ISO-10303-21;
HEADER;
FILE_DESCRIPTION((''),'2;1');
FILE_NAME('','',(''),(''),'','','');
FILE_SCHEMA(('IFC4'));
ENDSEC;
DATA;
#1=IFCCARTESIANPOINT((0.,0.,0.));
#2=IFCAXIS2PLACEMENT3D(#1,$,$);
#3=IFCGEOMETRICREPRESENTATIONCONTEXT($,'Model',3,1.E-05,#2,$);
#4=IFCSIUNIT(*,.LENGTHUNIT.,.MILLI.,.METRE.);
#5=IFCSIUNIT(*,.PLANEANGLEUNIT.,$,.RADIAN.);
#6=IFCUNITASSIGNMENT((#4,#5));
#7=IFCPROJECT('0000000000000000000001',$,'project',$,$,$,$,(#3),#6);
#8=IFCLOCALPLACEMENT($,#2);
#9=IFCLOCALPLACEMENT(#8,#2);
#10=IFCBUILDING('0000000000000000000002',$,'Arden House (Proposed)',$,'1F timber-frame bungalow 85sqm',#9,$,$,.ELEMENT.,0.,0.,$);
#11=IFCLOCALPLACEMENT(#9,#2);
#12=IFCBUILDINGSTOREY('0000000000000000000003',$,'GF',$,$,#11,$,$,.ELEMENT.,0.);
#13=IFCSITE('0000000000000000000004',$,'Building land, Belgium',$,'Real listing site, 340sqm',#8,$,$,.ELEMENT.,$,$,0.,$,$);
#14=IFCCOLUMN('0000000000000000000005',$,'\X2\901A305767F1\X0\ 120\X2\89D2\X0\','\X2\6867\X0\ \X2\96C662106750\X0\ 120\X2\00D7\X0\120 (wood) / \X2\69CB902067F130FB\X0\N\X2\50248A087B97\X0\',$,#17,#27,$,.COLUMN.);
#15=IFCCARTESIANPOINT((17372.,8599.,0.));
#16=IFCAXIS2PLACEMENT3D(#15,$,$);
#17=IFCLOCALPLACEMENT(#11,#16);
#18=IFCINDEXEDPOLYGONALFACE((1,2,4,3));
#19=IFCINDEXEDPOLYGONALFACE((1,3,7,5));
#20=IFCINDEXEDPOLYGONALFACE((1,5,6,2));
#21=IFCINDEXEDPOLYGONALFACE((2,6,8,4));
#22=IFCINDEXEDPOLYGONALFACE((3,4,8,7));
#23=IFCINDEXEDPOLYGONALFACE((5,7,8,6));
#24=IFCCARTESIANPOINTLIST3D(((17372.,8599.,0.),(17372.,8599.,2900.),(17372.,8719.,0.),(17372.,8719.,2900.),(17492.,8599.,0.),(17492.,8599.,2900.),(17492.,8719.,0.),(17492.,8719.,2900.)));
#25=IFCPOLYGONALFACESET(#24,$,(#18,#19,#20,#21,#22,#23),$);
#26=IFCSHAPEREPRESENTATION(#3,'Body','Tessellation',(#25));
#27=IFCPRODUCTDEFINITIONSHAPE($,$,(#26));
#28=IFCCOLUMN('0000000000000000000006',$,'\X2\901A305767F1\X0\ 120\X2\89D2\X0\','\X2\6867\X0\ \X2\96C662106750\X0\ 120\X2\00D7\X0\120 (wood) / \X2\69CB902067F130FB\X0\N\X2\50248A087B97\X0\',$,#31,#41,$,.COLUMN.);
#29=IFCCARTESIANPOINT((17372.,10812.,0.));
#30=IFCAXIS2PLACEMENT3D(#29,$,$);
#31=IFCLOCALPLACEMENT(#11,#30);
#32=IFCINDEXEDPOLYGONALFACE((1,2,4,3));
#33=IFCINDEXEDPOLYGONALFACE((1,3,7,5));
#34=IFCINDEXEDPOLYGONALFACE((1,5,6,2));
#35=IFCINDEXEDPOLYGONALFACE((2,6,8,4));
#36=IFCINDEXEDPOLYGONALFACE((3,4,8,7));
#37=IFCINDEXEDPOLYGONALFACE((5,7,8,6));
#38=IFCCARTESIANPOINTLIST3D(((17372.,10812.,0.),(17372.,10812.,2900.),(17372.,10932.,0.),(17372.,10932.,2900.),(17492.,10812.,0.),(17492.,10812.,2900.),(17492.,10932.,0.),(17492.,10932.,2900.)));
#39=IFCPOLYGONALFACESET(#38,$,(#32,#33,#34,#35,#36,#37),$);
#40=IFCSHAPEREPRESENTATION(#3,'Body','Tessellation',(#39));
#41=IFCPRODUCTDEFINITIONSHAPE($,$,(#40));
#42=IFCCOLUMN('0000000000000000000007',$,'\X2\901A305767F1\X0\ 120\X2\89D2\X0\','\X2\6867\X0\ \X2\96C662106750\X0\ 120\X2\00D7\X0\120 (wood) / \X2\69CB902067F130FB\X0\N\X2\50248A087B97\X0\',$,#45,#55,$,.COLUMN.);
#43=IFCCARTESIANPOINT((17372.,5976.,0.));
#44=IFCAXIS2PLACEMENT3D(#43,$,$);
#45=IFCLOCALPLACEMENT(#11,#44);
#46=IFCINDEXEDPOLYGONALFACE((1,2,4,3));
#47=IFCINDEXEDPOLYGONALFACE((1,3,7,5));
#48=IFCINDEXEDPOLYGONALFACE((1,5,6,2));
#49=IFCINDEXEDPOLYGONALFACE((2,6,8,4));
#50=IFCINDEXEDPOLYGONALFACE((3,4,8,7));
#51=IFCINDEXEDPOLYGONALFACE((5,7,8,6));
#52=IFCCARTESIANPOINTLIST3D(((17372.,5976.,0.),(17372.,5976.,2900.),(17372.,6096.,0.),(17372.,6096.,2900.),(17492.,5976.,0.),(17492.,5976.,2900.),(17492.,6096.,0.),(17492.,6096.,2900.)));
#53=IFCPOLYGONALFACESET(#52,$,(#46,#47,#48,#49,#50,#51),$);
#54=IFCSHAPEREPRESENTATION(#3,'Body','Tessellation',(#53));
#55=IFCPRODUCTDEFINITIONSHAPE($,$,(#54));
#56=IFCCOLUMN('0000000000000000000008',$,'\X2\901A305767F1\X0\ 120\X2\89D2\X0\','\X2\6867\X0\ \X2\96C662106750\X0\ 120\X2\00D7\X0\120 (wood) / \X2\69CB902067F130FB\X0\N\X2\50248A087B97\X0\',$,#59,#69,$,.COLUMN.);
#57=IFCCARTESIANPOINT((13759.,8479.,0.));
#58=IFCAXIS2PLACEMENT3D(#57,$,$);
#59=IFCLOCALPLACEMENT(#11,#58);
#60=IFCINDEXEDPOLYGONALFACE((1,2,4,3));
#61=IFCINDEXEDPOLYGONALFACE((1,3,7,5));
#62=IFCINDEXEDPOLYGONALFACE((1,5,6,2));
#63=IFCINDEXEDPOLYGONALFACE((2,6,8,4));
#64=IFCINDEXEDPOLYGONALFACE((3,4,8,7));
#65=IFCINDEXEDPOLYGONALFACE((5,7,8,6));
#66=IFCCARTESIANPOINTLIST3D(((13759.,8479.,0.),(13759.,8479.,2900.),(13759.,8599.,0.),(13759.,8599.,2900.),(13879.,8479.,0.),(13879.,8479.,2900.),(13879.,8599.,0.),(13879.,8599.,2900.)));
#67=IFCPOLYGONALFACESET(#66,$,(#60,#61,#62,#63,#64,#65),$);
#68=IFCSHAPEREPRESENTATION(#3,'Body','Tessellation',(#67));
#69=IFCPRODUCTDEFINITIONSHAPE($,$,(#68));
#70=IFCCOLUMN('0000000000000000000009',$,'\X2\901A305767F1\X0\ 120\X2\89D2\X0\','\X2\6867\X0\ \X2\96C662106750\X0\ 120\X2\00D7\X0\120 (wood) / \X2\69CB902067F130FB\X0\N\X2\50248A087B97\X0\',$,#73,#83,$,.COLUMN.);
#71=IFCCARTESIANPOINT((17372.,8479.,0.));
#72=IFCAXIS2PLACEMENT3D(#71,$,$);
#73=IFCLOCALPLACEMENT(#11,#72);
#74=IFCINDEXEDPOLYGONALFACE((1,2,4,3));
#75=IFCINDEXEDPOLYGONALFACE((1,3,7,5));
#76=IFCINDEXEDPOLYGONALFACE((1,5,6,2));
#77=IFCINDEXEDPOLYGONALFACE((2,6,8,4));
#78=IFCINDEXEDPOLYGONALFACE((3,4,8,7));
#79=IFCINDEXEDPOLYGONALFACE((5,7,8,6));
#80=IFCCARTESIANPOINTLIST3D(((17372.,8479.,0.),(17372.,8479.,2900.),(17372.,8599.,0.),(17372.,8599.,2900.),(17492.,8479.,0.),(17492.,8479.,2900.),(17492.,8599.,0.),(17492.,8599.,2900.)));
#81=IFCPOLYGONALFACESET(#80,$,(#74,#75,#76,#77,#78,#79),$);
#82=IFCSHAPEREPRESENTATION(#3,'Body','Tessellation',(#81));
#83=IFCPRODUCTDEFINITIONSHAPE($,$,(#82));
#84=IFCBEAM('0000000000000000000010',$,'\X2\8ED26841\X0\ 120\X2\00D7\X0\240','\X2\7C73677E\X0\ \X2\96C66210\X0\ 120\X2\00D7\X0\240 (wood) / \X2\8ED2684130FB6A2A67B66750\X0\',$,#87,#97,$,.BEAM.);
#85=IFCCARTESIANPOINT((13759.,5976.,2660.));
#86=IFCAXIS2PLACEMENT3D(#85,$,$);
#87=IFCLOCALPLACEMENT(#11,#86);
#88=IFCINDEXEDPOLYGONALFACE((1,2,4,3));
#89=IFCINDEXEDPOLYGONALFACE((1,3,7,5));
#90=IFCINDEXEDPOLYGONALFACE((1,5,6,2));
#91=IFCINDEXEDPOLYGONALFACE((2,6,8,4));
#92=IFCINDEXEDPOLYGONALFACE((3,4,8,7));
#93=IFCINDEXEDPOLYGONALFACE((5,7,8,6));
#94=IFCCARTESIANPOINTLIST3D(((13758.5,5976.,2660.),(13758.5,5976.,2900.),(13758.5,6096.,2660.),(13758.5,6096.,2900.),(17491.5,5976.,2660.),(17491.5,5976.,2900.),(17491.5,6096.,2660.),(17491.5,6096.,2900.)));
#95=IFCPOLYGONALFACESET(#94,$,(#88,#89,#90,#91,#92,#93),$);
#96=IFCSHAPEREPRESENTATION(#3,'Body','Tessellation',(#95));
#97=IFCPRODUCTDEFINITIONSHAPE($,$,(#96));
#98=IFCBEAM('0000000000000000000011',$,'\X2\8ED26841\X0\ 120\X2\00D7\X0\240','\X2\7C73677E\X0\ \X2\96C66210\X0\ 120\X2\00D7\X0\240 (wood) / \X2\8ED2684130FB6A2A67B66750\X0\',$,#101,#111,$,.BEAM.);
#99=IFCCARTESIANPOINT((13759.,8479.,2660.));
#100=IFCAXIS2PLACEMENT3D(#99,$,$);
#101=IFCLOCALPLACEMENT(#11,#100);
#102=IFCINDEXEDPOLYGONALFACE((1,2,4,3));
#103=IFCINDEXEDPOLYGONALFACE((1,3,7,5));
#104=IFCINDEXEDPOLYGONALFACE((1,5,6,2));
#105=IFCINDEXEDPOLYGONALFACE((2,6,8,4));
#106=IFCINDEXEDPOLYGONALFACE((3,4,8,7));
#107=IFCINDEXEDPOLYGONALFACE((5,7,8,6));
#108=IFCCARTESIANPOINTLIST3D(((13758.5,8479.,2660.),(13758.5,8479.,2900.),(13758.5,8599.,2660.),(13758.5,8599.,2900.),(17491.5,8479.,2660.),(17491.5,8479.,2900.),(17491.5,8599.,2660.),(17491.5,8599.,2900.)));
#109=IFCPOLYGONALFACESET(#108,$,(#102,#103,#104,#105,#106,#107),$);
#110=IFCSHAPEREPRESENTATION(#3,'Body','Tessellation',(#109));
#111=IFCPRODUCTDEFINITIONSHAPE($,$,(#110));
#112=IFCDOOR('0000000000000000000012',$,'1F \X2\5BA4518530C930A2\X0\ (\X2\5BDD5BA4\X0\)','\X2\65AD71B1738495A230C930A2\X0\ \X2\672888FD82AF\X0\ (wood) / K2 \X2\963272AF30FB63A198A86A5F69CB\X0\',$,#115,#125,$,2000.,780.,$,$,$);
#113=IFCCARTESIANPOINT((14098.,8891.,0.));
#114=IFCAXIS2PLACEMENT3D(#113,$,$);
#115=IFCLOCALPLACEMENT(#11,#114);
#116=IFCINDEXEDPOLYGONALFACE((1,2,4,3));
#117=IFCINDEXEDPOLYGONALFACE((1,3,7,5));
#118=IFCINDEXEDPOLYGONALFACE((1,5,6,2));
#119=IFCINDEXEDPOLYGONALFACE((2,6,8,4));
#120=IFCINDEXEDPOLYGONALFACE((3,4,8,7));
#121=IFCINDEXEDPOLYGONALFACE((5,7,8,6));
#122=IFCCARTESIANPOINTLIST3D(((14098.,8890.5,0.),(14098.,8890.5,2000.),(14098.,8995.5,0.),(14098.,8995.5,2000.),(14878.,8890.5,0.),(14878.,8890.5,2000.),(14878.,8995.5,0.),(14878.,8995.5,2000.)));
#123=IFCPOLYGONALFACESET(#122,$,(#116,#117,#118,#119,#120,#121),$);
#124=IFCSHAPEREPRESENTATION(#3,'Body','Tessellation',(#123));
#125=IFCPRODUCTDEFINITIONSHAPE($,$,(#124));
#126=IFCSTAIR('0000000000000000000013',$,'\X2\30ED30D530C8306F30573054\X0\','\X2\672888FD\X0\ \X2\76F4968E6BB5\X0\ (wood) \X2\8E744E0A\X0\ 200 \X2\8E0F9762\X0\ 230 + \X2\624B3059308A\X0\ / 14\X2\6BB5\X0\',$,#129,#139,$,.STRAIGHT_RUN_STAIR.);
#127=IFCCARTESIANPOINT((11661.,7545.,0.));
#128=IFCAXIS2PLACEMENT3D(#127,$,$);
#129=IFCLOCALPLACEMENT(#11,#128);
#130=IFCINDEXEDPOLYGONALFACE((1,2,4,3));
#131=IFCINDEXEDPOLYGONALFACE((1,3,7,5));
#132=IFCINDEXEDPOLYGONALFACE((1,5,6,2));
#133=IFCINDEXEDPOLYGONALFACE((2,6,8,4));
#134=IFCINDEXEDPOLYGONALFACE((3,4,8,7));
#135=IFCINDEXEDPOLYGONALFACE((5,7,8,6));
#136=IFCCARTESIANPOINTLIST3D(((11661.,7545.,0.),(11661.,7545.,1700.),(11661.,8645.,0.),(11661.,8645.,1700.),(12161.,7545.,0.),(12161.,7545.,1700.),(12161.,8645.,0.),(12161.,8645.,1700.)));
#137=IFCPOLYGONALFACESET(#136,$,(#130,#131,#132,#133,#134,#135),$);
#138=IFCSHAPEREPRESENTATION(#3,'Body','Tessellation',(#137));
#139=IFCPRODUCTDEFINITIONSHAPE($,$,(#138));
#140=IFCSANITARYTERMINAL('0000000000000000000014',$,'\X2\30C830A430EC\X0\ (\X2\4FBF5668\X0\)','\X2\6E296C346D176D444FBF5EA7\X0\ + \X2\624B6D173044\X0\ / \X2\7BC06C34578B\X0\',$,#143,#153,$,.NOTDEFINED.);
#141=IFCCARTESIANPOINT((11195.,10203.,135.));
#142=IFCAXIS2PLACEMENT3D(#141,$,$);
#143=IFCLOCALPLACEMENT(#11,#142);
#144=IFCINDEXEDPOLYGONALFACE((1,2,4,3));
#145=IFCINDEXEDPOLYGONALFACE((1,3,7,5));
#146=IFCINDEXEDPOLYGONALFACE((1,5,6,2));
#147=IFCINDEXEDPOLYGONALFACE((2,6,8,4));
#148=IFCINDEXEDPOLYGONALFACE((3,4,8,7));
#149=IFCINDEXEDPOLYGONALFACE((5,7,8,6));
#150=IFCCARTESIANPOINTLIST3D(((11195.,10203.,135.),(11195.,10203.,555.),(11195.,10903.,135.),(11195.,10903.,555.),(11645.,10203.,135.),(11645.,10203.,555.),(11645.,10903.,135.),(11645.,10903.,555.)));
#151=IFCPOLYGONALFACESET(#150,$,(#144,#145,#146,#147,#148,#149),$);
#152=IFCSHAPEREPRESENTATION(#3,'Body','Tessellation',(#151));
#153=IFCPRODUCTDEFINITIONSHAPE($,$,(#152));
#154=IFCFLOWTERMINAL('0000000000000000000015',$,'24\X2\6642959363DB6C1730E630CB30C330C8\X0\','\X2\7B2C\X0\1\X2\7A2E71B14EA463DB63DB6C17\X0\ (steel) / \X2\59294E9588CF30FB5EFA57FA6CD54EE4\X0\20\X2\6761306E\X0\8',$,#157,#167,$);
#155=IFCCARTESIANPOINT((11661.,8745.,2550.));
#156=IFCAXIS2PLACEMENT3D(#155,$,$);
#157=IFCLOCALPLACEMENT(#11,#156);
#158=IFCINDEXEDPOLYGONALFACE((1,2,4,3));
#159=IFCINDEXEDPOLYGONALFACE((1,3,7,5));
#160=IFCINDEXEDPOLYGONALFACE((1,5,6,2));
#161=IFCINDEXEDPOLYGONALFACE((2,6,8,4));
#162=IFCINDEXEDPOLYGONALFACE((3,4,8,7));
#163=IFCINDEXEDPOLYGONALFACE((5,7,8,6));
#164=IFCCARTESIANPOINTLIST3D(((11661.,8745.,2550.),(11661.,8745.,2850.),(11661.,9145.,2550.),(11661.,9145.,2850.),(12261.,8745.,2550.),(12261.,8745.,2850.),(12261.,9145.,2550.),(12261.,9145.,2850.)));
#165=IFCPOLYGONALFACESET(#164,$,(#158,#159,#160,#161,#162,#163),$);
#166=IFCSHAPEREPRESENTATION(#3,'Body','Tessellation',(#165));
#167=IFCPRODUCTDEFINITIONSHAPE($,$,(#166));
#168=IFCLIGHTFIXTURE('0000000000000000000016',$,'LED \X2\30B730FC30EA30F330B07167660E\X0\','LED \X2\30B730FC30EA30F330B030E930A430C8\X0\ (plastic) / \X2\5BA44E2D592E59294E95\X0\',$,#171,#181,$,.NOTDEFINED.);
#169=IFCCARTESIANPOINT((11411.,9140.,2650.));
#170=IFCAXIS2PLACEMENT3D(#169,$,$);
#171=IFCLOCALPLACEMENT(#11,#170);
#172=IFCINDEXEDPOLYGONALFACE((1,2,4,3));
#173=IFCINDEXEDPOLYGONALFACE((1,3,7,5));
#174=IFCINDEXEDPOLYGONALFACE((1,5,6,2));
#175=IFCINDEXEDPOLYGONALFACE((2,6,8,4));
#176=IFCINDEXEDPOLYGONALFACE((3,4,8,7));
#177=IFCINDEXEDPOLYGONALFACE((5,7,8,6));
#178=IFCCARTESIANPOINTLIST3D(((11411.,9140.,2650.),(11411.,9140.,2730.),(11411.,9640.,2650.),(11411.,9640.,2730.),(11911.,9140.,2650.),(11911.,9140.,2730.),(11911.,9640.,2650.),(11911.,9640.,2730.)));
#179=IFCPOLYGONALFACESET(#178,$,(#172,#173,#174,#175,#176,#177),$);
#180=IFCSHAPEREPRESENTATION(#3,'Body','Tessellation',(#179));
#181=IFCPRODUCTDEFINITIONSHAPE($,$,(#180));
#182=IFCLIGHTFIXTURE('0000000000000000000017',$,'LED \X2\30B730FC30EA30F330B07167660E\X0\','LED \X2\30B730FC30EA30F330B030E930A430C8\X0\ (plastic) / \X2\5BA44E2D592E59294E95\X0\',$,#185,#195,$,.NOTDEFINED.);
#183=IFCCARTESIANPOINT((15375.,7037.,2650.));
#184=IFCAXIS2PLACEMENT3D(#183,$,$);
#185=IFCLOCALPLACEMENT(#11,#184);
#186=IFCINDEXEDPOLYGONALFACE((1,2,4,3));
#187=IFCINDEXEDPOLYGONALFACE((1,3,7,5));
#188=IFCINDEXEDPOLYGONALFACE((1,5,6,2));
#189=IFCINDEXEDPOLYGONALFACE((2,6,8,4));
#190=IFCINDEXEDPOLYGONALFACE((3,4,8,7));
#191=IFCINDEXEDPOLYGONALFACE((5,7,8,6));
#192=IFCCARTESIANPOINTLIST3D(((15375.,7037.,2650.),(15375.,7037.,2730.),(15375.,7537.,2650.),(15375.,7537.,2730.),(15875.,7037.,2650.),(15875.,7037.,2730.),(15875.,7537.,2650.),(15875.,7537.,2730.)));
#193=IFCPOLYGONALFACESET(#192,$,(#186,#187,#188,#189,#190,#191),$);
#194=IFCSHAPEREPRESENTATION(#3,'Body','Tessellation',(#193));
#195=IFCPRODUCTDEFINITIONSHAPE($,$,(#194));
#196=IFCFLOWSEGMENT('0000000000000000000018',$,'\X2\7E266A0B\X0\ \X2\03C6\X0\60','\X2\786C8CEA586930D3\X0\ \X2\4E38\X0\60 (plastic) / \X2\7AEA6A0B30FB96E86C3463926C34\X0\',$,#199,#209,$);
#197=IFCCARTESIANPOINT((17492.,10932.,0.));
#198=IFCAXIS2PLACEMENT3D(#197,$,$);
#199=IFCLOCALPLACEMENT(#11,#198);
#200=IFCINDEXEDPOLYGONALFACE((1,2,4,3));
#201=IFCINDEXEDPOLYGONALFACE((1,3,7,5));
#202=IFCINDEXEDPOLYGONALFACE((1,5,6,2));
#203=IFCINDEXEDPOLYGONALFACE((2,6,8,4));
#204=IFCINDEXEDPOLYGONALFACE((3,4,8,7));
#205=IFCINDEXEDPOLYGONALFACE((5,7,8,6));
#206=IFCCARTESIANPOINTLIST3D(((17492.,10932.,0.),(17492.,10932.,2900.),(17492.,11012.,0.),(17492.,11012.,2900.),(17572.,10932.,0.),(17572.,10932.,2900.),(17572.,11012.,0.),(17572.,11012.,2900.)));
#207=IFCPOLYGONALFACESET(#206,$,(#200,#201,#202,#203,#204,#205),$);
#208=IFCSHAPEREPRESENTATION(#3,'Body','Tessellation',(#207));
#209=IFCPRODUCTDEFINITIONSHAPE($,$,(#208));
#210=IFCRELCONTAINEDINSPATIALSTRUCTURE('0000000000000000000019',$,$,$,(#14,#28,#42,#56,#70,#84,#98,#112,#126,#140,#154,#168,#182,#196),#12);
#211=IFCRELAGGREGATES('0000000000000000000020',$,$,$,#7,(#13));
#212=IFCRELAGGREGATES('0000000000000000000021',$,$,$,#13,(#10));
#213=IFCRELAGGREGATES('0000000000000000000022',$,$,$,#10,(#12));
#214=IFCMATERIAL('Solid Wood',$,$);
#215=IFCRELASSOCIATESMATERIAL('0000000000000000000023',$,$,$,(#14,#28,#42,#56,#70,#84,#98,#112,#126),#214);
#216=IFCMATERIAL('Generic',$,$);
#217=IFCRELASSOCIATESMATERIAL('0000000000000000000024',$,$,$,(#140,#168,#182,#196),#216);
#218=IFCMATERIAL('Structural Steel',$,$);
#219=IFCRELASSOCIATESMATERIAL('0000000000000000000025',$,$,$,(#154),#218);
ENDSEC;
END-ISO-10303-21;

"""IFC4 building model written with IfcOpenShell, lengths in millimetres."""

from ifc_helpers import new_model, si_unit, frame, frame_2d, origin, place, context, project, spatial, rectangle, extrude, material, element, save


model = new_model("IFC4")

# Units and contexts
model_context = context("Model", 3, precision=1e-05, world=origin())
ifc_project = project(units=[si_unit("LENGTHUNIT", "METRE", prefix="MILLI"), si_unit("PLANEANGLEUNIT", "RADIAN")], contexts=[model_context])

# Site, building, storey
site_placement = place(None, origin())
site = spatial("IfcSite", under=ifc_project, at=site_placement, Name="Building land, Belgium", ObjectType="Real listing site, 340sqm", CompositionType="ELEMENT", RefElevation=0.0)
building_placement = place(site_placement, origin())
building = spatial("IfcBuilding", under=site, at=building_placement, Name="Arden House (Proposed)", ObjectType="1F timber-frame bungalow 85sqm", CompositionType="ELEMENT", ElevationOfRefHeight=0.0, ElevationOfTerrain=0.0)
storey_placement = place(building_placement, origin())
storey = spatial("IfcBuildingStorey", under=building, at=storey_placement, Name="GF", CompositionType="ELEMENT", Elevation=0.0)

# Columns
ifc_material_1 = material(Name="Solid Wood")
column_1_placement = place(storey_placement, frame((17372.0, 8599.0, 0.0)))
element("IfcColumn", 1, at=column_1_placement, inside=storey, material=ifc_material_1, Name="通し柱 120角", Description="桧 集成材 120×120 (wood) / 構造柱・N値計算", PredefinedType="COLUMN", context=model_context, shape_type="SweptSolid", body=[
    extrude(rectangle(XDim=120.0, YDim=120.0, at=frame_2d((60.0, 60.0))), frame((17372.0, 8599.0, 0.0)), (0.0, 0.0, 1.0), 2900.0),
])
column_2_placement = place(storey_placement, frame((17372.0, 10812.0, 0.0)))
element("IfcColumn", 2, at=column_2_placement, inside=storey, material=ifc_material_1, Name="通し柱 120角", Description="桧 集成材 120×120 (wood) / 構造柱・N値計算", PredefinedType="COLUMN", context=model_context, shape_type="SweptSolid", body=[
    extrude(rectangle(XDim=120.0, YDim=120.0, at=frame_2d((60.0, 60.0))), frame((17372.0, 10812.0, 0.0)), (0.0, 0.0, 1.0), 2900.0),
])
column_3_placement = place(storey_placement, frame((17372.0, 5976.0, 0.0)))
element("IfcColumn", 3, at=column_3_placement, inside=storey, material=ifc_material_1, Name="通し柱 120角", Description="桧 集成材 120×120 (wood) / 構造柱・N値計算", PredefinedType="COLUMN", context=model_context, shape_type="SweptSolid", body=[
    extrude(rectangle(XDim=120.0, YDim=120.0, at=frame_2d((60.0, 60.0))), frame((17372.0, 5976.0, 0.0)), (0.0, 0.0, 1.0), 2900.0),
])
column_4_placement = place(storey_placement, frame((13759.0, 8479.0, 0.0)))
element("IfcColumn", 4, at=column_4_placement, inside=storey, material=ifc_material_1, Name="通し柱 120角", Description="桧 集成材 120×120 (wood) / 構造柱・N値計算", PredefinedType="COLUMN", context=model_context, shape_type="SweptSolid", body=[
    extrude(rectangle(XDim=120.0, YDim=120.0, at=frame_2d((60.0, 60.0))), frame((13759.0, 8479.0, 0.0)), (0.0, 0.0, 1.0), 2900.0),
])
column_5_placement = place(storey_placement, frame((17372.0, 8479.0, 0.0)))
element("IfcColumn", 5, at=column_5_placement, inside=storey, material=ifc_material_1, Name="通し柱 120角", Description="桧 集成材 120×120 (wood) / 構造柱・N値計算", PredefinedType="COLUMN", context=model_context, shape_type="SweptSolid", body=[
    extrude(rectangle(XDim=120.0, YDim=120.0, at=frame_2d((60.0, 60.0))), frame((17372.0, 8479.0, 0.0)), (0.0, 0.0, 1.0), 2900.0),
])

# Beams
beam_1_placement = place(storey_placement, frame((13759.0, 5976.0, 2660.0)))
element("IfcBeam", 6, at=beam_1_placement, inside=storey, material=ifc_material_1, Name="軒桁 120×240", Description="米松 集成 120×240 (wood) / 軒桁・横架材", PredefinedType="BEAM", context=model_context, shape_type="SweptSolid", body=[
    extrude(rectangle(XDim=3733.0, YDim=120.0, at=frame_2d((1866.0, 60.0))), frame((13759.0, 5976.0, 2660.0)), (0.0, 0.0, 1.0), 240.0),
])
beam_2_placement = place(storey_placement, frame((13759.0, 8479.0, 2660.0)))
element("IfcBeam", 7, at=beam_2_placement, inside=storey, material=ifc_material_1, Name="軒桁 120×240", Description="米松 集成 120×240 (wood) / 軒桁・横架材", PredefinedType="BEAM", context=model_context, shape_type="SweptSolid", body=[
    extrude(rectangle(XDim=3733.0, YDim=120.0, at=frame_2d((1866.0, 60.0))), frame((13759.0, 8479.0, 2660.0)), (0.0, 0.0, 1.0), 240.0),
])

# Door
door_placement = place(storey_placement, frame((14098.0, 8891.0, 0.0)))
element("IfcDoor", 8, at=door_placement, inside=storey, material=ifc_material_1, Name="1F 室内ドア (寝室)", Description="断熱玄関ドア 木製芯 (wood) / K2 防犯・採風機構", OverallHeight=2000.0, OverallWidth=780.0, context=model_context, shape_type="SweptSolid", body=[
    extrude(rectangle(XDim=780.0, YDim=105.0, at=frame_2d((390.0, 52.0))), frame((14098.0, 8891.0, 0.0)), (0.0, 0.0, 1.0), 2000.0),
])

# Stair
stair_placement = place(storey_placement, frame((11661.0, 7545.0, 0.0)))
element("IfcStair", 9, at=stair_placement, inside=storey, material=ifc_material_1, Name="ロフトはしご", Description="木製 直階段 (wood) 蹴上 200 踏面 230 + 手すり / 14段", PredefinedType="STRAIGHT_RUN_STAIR", context=model_context, shape_type="SweptSolid", body=[
    extrude(rectangle(XDim=500.0, YDim=1100.0, at=frame_2d((250.0, 550.0))), frame((11661.0, 7545.0, 0.0)), (0.0, 0.0, 1.0), 1700.0),
])

# Shared definitions
ifc_material_2 = material(Name="Generic")

# Sanitary terminal
sanitary_terminal_placement = place(storey_placement, frame((11195.0, 10203.0, 135.0)))
element("IfcSanitaryTerminal", 10, at=sanitary_terminal_placement, inside=storey, material=ifc_material_2, Name="トイレ (便器)", Description="温水洗浄便座 + 手洗い / 節水型", PredefinedType="NOTDEFINED", context=model_context, shape_type="SweptSolid", body=[
    extrude(rectangle(XDim=450.0, YDim=700.0, at=frame_2d((225.0, 350.0))), frame((11195.0, 10203.0, 135.0)), (0.0, 0.0, 1.0), 420.0),
])

# Flow terminal
ifc_material_3 = material(Name="Structural Steel")
flow_terminal_placement = place(storey_placement, frame((11661.0, 8745.0, 2550.0)))
element("IfcFlowTerminal", 11, at=flow_terminal_placement, inside=storey, material=ifc_material_3, Name="24時間換気ユニット", Description="第1種熱交換換気 (steel) / 天井裏・建基法令20条の8", context=model_context, shape_type="SweptSolid", body=[
    extrude(rectangle(XDim=600.0, YDim=400.0, at=frame_2d((300.0, 200.0))), frame((11661.0, 8745.0, 2550.0)), (0.0, 0.0, 1.0), 300.0),
])

# Light fixtures
light_fixture_1_placement = place(storey_placement, frame((11411.0, 9140.0, 2650.0)))
element("IfcLightFixture", 12, at=light_fixture_1_placement, inside=storey, material=ifc_material_2, Name="LED シーリング照明", Description="LED シーリングライト (plastic) / 室中央天井", PredefinedType="NOTDEFINED", context=model_context, shape_type="SweptSolid", body=[
    extrude(rectangle(XDim=500.0, YDim=500.0, at=frame_2d((250.0, 250.0))), frame((11411.0, 9140.0, 2650.0)), (0.0, 0.0, 1.0), 80.0),
])
light_fixture_2_placement = place(storey_placement, frame((15375.0, 7037.0, 2650.0)))
element("IfcLightFixture", 13, at=light_fixture_2_placement, inside=storey, material=ifc_material_2, Name="LED シーリング照明", Description="LED シーリングライト (plastic) / 室中央天井", PredefinedType="NOTDEFINED", context=model_context, shape_type="SweptSolid", body=[
    extrude(rectangle(XDim=500.0, YDim=500.0, at=frame_2d((250.0, 250.0))), frame((15375.0, 7037.0, 2650.0)), (0.0, 0.0, 1.0), 80.0),
])

# Flow segment
flow_segment_placement = place(storey_placement, frame((17492.0, 10932.0, 0.0)))
element("IfcFlowSegment", 14, at=flow_segment_placement, inside=storey, material=ifc_material_2, Name="縦樋 φ60", Description="硬質塩ビ 丸60 (plastic) / 竪樋・雨水排水", context=model_context, shape_type="SweptSolid", body=[
    extrude(rectangle(XDim=80.0, YDim=80.0, at=frame_2d((40.0, 40.0))), frame((17492.0, 10932.0, 0.0)), (0.0, 0.0, 1.0), 2900.0),
])

save(model, "model.ifc")
